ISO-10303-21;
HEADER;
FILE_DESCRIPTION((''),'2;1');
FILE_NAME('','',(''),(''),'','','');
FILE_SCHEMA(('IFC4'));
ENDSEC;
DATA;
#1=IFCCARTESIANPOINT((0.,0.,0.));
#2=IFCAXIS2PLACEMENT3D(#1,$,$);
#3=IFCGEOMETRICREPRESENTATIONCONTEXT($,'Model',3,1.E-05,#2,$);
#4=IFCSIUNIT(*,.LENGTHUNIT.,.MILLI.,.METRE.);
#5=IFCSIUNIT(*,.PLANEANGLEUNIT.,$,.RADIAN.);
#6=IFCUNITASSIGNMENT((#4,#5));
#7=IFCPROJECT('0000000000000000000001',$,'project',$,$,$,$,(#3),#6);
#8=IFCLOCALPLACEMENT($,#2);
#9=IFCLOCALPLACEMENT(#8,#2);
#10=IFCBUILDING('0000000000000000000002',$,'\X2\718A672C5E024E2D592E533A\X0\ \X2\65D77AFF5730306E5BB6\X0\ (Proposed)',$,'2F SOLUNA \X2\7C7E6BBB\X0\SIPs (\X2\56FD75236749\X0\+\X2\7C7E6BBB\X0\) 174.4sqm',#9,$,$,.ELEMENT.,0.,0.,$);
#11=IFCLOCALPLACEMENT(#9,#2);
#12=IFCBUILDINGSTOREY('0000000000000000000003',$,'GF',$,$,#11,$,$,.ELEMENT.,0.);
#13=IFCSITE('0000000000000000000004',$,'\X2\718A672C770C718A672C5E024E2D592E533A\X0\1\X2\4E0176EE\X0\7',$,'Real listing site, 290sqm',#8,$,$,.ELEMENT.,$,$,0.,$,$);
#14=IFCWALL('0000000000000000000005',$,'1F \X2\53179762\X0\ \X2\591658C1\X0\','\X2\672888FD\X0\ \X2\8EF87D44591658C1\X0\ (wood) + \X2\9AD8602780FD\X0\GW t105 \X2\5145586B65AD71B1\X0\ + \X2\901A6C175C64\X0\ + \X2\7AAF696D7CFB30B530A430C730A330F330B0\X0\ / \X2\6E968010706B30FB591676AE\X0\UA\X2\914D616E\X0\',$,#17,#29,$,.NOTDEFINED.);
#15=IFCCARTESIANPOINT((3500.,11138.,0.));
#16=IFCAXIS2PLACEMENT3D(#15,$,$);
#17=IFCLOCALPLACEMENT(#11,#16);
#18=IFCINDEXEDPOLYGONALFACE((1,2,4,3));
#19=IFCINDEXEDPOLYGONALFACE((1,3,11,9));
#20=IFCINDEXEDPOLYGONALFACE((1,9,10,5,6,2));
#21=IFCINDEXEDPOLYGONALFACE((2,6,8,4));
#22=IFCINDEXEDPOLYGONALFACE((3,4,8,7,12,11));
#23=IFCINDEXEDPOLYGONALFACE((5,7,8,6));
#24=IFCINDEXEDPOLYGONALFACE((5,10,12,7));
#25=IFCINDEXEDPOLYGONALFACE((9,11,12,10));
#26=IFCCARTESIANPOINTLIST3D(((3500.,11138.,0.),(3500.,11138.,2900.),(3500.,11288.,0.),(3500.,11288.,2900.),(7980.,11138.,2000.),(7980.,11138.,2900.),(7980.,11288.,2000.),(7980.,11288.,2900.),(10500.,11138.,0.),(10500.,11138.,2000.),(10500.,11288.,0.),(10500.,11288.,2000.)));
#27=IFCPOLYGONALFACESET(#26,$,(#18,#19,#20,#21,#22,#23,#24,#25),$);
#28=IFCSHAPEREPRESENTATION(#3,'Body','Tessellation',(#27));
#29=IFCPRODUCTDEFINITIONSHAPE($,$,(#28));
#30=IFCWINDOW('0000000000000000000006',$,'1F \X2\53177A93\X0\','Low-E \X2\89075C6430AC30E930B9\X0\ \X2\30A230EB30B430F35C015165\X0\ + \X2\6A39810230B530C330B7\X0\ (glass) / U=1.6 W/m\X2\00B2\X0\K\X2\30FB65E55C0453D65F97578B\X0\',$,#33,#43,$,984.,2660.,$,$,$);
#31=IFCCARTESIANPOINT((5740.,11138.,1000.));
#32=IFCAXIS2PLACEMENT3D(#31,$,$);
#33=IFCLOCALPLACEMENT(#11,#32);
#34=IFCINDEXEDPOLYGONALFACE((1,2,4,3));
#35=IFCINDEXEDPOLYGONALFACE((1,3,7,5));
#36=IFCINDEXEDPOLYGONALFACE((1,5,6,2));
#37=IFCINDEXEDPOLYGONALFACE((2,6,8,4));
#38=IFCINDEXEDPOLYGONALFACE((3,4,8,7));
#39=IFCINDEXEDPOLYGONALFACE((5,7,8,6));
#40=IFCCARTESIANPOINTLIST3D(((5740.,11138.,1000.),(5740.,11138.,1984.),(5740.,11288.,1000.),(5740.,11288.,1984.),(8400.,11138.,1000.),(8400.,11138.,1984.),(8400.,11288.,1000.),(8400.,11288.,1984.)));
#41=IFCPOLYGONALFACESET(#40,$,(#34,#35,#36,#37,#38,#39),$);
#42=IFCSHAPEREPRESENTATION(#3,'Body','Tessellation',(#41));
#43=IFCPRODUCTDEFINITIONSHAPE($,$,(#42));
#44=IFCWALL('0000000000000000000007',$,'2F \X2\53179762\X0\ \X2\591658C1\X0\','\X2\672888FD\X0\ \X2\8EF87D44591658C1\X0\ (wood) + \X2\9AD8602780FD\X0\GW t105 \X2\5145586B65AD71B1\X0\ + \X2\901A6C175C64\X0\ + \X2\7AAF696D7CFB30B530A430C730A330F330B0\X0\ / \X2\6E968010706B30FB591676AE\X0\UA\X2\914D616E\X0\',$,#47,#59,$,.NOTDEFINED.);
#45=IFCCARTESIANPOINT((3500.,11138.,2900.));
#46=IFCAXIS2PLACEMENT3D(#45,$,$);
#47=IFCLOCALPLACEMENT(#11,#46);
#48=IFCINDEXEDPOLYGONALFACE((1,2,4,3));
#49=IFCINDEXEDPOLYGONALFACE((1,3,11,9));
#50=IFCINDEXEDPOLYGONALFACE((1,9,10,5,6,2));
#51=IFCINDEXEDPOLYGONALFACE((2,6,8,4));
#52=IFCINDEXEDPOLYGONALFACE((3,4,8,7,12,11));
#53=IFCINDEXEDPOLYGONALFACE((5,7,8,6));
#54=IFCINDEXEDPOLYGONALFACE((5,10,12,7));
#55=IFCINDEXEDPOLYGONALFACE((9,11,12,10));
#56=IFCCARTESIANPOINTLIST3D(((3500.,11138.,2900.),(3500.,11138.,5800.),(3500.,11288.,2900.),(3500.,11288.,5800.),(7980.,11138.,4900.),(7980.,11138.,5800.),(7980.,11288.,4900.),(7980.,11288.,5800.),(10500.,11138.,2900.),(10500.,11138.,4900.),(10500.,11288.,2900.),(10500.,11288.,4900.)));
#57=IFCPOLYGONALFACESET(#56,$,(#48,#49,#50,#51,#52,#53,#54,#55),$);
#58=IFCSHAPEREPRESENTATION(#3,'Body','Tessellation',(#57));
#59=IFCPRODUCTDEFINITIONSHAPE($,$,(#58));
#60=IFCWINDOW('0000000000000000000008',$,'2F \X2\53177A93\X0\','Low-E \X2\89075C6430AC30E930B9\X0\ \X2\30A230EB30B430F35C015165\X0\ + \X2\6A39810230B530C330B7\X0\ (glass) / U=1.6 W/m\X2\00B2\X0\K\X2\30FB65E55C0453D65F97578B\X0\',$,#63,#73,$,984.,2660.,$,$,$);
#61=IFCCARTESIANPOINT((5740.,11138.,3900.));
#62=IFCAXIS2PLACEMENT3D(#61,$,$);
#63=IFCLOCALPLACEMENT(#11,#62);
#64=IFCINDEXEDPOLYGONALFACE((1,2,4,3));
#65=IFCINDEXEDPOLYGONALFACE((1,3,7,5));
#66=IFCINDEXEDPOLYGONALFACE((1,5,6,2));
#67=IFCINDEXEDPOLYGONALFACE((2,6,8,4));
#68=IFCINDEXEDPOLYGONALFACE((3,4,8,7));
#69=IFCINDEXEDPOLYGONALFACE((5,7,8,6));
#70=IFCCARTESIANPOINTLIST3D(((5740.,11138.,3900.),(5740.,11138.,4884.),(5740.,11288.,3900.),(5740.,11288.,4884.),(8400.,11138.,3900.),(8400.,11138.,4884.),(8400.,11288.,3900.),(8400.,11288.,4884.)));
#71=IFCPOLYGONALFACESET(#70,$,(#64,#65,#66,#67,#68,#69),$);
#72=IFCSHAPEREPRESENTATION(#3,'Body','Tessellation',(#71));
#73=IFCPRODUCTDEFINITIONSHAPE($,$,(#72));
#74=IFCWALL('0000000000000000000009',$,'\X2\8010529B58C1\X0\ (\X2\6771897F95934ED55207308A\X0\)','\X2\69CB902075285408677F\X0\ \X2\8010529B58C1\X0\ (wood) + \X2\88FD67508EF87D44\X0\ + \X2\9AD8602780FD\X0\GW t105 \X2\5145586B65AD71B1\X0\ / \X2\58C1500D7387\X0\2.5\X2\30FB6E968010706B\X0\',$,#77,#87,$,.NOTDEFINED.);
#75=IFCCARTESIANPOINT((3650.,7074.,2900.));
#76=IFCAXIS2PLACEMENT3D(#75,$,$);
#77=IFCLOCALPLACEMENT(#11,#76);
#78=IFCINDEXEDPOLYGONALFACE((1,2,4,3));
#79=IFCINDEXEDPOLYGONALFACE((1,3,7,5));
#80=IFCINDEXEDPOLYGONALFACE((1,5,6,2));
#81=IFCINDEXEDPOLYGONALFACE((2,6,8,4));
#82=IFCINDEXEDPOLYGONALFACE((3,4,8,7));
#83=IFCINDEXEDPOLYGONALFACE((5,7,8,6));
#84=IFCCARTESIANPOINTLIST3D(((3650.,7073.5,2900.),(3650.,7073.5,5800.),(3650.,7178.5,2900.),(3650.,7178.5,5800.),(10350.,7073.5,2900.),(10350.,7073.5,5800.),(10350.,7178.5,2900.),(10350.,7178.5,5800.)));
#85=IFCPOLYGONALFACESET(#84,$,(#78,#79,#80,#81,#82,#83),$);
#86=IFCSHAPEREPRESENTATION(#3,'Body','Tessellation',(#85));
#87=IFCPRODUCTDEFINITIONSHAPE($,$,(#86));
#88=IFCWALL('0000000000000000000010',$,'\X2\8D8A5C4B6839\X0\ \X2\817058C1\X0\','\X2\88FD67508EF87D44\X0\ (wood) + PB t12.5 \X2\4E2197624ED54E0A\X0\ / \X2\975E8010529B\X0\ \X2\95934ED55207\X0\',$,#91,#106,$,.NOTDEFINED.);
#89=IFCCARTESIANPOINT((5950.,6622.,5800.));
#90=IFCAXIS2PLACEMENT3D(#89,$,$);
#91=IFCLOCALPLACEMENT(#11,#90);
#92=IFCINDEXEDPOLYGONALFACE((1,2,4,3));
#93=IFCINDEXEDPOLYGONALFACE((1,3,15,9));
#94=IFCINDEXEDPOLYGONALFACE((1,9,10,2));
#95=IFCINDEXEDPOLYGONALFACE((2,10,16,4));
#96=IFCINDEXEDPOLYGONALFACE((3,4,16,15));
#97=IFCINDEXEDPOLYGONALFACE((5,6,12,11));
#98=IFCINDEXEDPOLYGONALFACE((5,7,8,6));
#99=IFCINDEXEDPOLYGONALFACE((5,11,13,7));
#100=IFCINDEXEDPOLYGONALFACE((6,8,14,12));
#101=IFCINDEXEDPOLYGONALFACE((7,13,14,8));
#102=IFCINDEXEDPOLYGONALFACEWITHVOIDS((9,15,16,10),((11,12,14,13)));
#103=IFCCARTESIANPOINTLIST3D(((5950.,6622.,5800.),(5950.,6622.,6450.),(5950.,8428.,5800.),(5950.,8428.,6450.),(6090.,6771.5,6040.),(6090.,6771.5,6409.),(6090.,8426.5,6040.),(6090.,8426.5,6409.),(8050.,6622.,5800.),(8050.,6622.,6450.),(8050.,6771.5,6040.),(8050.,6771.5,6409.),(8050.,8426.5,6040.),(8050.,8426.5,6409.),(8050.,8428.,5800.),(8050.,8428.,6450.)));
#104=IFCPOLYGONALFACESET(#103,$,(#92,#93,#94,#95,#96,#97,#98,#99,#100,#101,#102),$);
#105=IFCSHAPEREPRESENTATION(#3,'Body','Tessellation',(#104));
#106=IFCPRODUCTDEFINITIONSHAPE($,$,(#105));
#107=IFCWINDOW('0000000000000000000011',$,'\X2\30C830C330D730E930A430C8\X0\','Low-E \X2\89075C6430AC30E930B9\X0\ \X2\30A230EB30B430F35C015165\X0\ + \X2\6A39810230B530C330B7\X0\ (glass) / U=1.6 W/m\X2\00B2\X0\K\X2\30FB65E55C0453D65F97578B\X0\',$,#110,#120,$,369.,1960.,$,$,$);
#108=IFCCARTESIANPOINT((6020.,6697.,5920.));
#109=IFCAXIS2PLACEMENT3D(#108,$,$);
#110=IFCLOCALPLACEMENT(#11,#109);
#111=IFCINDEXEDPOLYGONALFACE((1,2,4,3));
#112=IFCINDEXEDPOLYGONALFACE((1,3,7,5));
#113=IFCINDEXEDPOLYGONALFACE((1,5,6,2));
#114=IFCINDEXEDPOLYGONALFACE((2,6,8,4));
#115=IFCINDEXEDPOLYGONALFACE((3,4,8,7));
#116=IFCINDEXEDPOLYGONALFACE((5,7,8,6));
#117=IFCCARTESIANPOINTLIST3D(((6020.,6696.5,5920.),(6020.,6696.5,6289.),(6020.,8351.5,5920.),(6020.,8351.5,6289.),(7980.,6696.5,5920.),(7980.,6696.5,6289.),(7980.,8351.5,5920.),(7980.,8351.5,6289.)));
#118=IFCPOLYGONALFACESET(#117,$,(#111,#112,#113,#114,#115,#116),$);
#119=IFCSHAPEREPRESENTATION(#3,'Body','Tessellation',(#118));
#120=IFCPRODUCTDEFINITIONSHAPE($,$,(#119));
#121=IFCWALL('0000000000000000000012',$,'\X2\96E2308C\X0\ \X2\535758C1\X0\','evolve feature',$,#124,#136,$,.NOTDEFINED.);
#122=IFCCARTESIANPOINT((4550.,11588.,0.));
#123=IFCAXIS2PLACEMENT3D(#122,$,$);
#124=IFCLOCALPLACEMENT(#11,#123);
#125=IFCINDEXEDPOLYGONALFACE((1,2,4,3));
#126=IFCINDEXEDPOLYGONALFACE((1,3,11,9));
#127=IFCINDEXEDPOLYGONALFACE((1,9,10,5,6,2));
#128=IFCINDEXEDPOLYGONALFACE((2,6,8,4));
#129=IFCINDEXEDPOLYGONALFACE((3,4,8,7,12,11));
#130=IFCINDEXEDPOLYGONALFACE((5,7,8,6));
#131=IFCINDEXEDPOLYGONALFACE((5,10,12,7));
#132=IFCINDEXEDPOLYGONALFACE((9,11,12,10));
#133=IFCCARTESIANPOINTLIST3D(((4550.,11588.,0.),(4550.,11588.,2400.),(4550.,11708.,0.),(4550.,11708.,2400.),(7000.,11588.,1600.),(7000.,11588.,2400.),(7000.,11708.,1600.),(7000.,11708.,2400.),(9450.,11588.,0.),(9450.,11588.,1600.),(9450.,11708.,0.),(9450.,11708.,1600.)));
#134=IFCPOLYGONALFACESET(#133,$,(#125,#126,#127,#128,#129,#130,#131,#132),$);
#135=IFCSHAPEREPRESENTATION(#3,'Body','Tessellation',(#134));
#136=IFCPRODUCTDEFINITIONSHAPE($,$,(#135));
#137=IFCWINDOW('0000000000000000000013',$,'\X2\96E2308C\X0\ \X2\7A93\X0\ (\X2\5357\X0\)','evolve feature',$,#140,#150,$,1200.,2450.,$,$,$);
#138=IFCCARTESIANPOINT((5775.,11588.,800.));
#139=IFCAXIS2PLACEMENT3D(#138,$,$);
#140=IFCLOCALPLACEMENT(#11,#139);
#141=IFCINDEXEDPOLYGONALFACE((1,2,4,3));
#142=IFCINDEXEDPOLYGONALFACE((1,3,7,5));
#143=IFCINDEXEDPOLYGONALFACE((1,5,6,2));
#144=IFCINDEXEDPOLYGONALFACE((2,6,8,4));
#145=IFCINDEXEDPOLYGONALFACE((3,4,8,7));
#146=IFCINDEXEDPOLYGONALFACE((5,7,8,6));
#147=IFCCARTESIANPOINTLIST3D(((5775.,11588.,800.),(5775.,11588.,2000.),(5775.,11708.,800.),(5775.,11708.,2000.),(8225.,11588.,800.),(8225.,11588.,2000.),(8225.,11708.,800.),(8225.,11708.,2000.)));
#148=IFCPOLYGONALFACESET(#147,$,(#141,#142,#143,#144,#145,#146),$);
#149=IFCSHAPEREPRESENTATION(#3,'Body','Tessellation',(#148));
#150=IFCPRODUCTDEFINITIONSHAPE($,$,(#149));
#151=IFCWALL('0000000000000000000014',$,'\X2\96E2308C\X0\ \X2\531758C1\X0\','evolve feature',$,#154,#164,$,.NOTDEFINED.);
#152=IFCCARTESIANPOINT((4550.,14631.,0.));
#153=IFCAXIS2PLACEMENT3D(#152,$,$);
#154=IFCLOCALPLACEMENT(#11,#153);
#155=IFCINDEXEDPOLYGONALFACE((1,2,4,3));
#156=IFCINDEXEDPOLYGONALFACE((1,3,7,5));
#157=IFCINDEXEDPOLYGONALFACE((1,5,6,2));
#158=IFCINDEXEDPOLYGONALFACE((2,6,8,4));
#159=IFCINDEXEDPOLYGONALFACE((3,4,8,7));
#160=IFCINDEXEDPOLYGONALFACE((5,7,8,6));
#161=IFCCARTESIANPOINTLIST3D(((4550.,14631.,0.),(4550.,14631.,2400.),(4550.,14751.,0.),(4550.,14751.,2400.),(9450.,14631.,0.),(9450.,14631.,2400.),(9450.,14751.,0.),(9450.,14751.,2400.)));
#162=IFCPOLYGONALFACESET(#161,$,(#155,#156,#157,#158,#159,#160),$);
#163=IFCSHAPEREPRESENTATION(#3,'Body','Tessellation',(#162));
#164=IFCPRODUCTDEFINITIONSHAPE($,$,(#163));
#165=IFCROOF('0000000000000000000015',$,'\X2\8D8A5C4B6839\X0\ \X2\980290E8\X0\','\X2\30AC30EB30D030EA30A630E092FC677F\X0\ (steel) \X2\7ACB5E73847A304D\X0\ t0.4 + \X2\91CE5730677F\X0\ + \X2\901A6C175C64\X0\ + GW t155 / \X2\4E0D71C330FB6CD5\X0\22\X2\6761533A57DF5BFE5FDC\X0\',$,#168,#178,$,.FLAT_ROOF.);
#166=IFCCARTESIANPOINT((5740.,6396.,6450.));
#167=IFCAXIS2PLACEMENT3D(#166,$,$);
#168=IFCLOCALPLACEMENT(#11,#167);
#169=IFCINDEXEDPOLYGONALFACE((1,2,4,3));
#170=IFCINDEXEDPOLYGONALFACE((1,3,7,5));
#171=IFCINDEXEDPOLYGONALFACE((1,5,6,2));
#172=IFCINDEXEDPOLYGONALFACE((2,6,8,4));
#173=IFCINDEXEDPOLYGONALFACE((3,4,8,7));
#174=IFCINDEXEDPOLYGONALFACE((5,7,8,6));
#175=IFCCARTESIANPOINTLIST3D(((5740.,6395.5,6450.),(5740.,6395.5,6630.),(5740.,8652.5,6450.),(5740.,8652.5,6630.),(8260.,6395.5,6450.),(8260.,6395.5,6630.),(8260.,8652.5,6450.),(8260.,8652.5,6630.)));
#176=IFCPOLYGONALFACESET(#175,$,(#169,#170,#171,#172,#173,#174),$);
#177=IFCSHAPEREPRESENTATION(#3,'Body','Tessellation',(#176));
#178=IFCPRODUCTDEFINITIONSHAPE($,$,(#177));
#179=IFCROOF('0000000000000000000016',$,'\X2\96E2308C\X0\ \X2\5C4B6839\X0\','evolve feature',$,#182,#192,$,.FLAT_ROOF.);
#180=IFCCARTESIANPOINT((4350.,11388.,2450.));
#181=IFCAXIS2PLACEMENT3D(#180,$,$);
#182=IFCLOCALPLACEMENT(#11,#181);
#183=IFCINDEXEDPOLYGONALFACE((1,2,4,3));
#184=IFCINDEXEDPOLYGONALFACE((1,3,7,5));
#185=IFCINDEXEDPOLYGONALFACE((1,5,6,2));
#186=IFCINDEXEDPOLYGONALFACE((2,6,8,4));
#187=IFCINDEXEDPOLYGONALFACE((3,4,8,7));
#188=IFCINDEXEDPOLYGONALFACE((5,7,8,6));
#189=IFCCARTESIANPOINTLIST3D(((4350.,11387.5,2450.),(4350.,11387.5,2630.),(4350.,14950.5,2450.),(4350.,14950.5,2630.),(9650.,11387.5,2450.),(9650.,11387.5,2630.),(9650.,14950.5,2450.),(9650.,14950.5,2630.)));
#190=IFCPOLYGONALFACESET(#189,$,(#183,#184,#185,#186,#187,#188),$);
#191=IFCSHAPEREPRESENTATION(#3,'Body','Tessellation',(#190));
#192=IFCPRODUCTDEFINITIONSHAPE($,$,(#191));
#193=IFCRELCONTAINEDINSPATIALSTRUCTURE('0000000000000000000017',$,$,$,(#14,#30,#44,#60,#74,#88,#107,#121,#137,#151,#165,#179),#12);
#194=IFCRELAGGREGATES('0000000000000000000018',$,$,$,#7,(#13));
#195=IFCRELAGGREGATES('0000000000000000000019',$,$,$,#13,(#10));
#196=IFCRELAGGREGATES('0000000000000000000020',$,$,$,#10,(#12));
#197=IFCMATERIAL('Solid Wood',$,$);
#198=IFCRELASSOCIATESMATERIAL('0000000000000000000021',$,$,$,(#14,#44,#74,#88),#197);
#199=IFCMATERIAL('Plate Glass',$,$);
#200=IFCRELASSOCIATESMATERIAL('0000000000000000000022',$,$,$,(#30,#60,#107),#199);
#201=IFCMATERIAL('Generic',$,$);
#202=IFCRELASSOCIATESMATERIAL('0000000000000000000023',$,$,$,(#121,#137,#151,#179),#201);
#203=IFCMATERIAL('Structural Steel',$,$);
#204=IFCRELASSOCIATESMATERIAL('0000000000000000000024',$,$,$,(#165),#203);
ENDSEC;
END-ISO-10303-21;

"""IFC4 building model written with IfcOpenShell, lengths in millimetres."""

from ifc_helpers import new_model, si_unit, frame, frame_2d, origin, place, context, project, spatial, rectangle, extrude, material, element, fill, save


model = new_model("IFC4")

# Units and contexts
model_context = context("Model", 3, precision=1e-05, world=origin())
ifc_project = project(units=[si_unit("LENGTHUNIT", "METRE", prefix="MILLI"), si_unit("PLANEANGLEUNIT", "RADIAN")], contexts=[model_context])

# Site, building, storey
site_placement = place(None, origin())
site = spatial("IfcSite", under=ifc_project, at=site_placement, Name="熊本県熊本市中央区1丁目7", ObjectType="Real listing site, 290sqm", CompositionType="ELEMENT", RefElevation=0.0)
building_placement = place(site_placement, origin())
building = spatial("IfcBuilding", under=site, at=building_placement, Name="熊本市中央区 旗竿地の家 (Proposed)", ObjectType="2F SOLUNA 籾殻SIPs (国産杉+籾殻) 174.4sqm", CompositionType="ELEMENT", ElevationOfRefHeight=0.0, ElevationOfTerrain=0.0)
storey_placement = place(building_placement, origin())
storey = spatial("IfcBuildingStorey", under=building, at=storey_placement, Name="GF", CompositionType="ELEMENT", Elevation=0.0)

# Shared definitions
ifc_material_1 = material(Name="Generic")

# Wall, opening, window
ifc_material_2 = material(Name="Solid Wood")
wall_1_placement = place(storey_placement, frame((3500.0, 11138.0, 0.0)))
wall_1 = element("IfcWall", 1, at=wall_1_placement, inside=storey, material=ifc_material_2, Name="1F 北面 外壁", Description="木製 軸組外壁 (wood) + 高性能GW t105 充填断熱 + 通気層 + 窯業系サイディング / 準耐火・外皮UA配慮", PredefinedType="NOTDEFINED", context=model_context, shape_type="SweptSolid", body=[
    extrude(rectangle(XDim=7000.0, YDim=150.0, at=frame_2d((3500.0, 75.0))), frame((3500.0, 11138.0, 0.0)), (0.0, 0.0, 1.0), 2900.0),
])
opening_1_placement = place(storey_placement, frame((5740.0, 11138.0, 1000.0)))
opening_1 = element("IfcOpeningElement", 2, at=opening_1_placement, cuts=wall_1, PredefinedType="NOTDEFINED", context=model_context, shape_type="SweptSolid", body=[
    extrude(rectangle(XDim=2660.0, YDim=150.0, at=frame_2d((1330.0, 75.0))), frame((5740.0, 11138.0, 1000.0)), (0.0, 0.0, 1.0), 984.0),
])
ifc_material_3 = material(Name="Plate Glass")
window_1_placement = place(storey_placement, frame((5740.0, 11138.0, 1000.0)))
window_1 = element("IfcWindow", 3, at=window_1_placement, inside=storey, material=ifc_material_3, Name="1F 北窓", Description="Low-E 複層ガラス アルゴン封入 + 樹脂サッシ (glass) / U=1.6 W/m²K・日射取得型", OverallHeight=984.0, OverallWidth=2660.0, context=model_context, shape_type="SweptSolid", body=[
    extrude(rectangle(XDim=2660.0, YDim=150.0, at=frame_2d((1330.0, 75.0))), frame((5740.0, 11138.0, 1000.0)), (0.0, 0.0, 1.0), 984.0),
])
fill(opening_1, window_1)

# Wall, opening, window
wall_2_placement = place(storey_placement, frame((3500.0, 11138.0, 2900.0)))
wall_2 = element("IfcWall", 4, at=wall_2_placement, inside=storey, material=ifc_material_2, Name="2F 北面 外壁", Description="木製 軸組外壁 (wood) + 高性能GW t105 充填断熱 + 通気層 + 窯業系サイディング / 準耐火・外皮UA配慮", PredefinedType="NOTDEFINED", context=model_context, shape_type="SweptSolid", body=[
    extrude(rectangle(XDim=7000.0, YDim=150.0, at=frame_2d((3500.0, 75.0))), frame((3500.0, 11138.0, 2900.0)), (0.0, 0.0, 1.0), 2900.0),
])
opening_2_placement = place(storey_placement, frame((5740.0, 11138.0, 3900.0)))
opening_2 = element("IfcOpeningElement", 5, at=opening_2_placement, cuts=wall_2, PredefinedType="NOTDEFINED", context=model_context, shape_type="SweptSolid", body=[
    extrude(rectangle(XDim=2660.0, YDim=150.0, at=frame_2d((1330.0, 75.0))), frame((5740.0, 11138.0, 3900.0)), (0.0, 0.0, 1.0), 984.0),
])
window_2_placement = place(storey_placement, frame((5740.0, 11138.0, 3900.0)))
window_2 = element("IfcWindow", 6, at=window_2_placement, inside=storey, material=ifc_material_3, Name="2F 北窓", Description="Low-E 複層ガラス アルゴン封入 + 樹脂サッシ (glass) / U=1.6 W/m²K・日射取得型", OverallHeight=984.0, OverallWidth=2660.0, context=model_context, shape_type="SweptSolid", body=[
    extrude(rectangle(XDim=2660.0, YDim=150.0, at=frame_2d((1330.0, 75.0))), frame((5740.0, 11138.0, 3900.0)), (0.0, 0.0, 1.0), 984.0),
])
fill(opening_2, window_2)

# Wall
wall_3_placement = place(storey_placement, frame((3650.0, 7074.0, 2900.0)))
element("IfcWall", 7, at=wall_3_placement, inside=storey, material=ifc_material_2, Name="耐力壁 (東西間仕切り)", Description="構造用合板 耐力壁 (wood) + 製材軸組 + 高性能GW t105 充填断熱 / 壁倍率2.5・準耐火", PredefinedType="NOTDEFINED", context=model_context, shape_type="SweptSolid", body=[
    extrude(rectangle(XDim=6700.0, YDim=105.0, at=frame_2d((3350.0, 52.0))), frame((3650.0, 7074.0, 2900.0)), (0.0, 0.0, 1.0), 2900.0),
])

# Walls, openings, windows
wall_4_placement = place(storey_placement, frame((5950.0, 6622.0, 5800.0)))
wall_4 = element("IfcWall", 8, at=wall_4_placement, inside=storey, material=ifc_material_2, Name="越屋根 腰壁", Description="製材軸組 (wood) + PB t12.5 両面仕上 / 非耐力 間仕切", PredefinedType="NOTDEFINED", context=model_context, shape_type="SweptSolid", body=[
    extrude(rectangle(XDim=2100.0, YDim=1806.0, at=frame_2d((1050.0, 903.0))), frame((5950.0, 6622.0, 5800.0)), (0.0, 0.0, 1.0), 650.0),
])
opening_3_placement = place(storey_placement, frame((6020.0, 6697.0, 5920.0)))
opening_3 = element("IfcOpeningElement", 9, at=opening_3_placement, cuts=wall_4, PredefinedType="NOTDEFINED", context=model_context, shape_type="SweptSolid", body=[
    extrude(rectangle(XDim=1960.0, YDim=1655.0, at=frame_2d((980.0, 827.0))), frame((6020.0, 6697.0, 5920.0)), (0.0, 0.0, 1.0), 369.0),
])
window_3_placement = place(storey_placement, frame((6020.0, 6697.0, 5920.0)))
window_3 = element("IfcWindow", 10, at=window_3_placement, inside=storey, material=ifc_material_3, Name="トップライト", Description="Low-E 複層ガラス アルゴン封入 + 樹脂サッシ (glass) / U=1.6 W/m²K・日射取得型", OverallHeight=369.0, OverallWidth=1960.0, context=model_context, shape_type="SweptSolid", body=[
    extrude(rectangle(XDim=1960.0, YDim=1655.0, at=frame_2d((980.0, 827.0))), frame((6020.0, 6697.0, 5920.0)), (0.0, 0.0, 1.0), 369.0),
])
fill(opening_3, window_3)
wall_5_placement = place(storey_placement, frame((4550.0, 11588.0, 0.0)))
wall_5 = element("IfcWall", 11, at=wall_5_placement, inside=storey, material=ifc_material_1, Name="離れ 南壁", Description="evolve feature", PredefinedType="NOTDEFINED", context=model_context, shape_type="SweptSolid", body=[
    extrude(rectangle(XDim=4900.0, YDim=120.0, at=frame_2d((2450.0, 60.0))), frame((4550.0, 11588.0, 0.0)), (0.0, 0.0, 1.0), 2400.0),
])
opening_4_placement = place(storey_placement, frame((5775.0, 11588.0, 800.0)))
opening_4 = element("IfcOpeningElement", 12, at=opening_4_placement, cuts=wall_5, PredefinedType="NOTDEFINED", context=model_context, shape_type="SweptSolid", body=[
    extrude(rectangle(XDim=2450.0, YDim=120.0, at=frame_2d((1225.0, 60.0))), frame((5775.0, 11588.0, 800.0)), (0.0, 0.0, 1.0), 1200.0),
])
window_4_placement = place(storey_placement, frame((5775.0, 11588.0, 800.0)))
window_4 = element("IfcWindow", 13, at=window_4_placement, inside=storey, material=ifc_material_1, Name="離れ 窓 (南)", Description="evolve feature", OverallHeight=1200.0, OverallWidth=2450.0, context=model_context, shape_type="SweptSolid", body=[
    extrude(rectangle(XDim=2450.0, YDim=120.0, at=frame_2d((1225.0, 60.0))), frame((5775.0, 11588.0, 800.0)), (0.0, 0.0, 1.0), 1200.0),
])
fill(opening_4, window_4)

# Wall
wall_6_placement = place(storey_placement, frame((4550.0, 14631.0, 0.0)))
element("IfcWall", 14, at=wall_6_placement, inside=storey, material=ifc_material_1, Name="離れ 北壁", Description="evolve feature", PredefinedType="NOTDEFINED", context=model_context, shape_type="SweptSolid", body=[
    extrude(rectangle(XDim=4900.0, YDim=120.0, at=frame_2d((2450.0, 60.0))), frame((4550.0, 14631.0, 0.0)), (0.0, 0.0, 1.0), 2400.0),
])

# Roofs
ifc_material_4 = material(Name="Structural Steel")
roof_1_placement = place(storey_placement, frame((5740.0, 6396.0, 6450.0)))
element("IfcRoof", 15, at=roof_1_placement, inside=storey, material=ifc_material_4, Name="越屋根 頂部", Description="ガルバリウム鋼板 (steel) 立平葺き t0.4 + 野地板 + 通気層 + GW t155 / 不燃・法22条区域対応", PredefinedType="FLAT_ROOF", context=model_context, shape_type="SweptSolid", body=[
    extrude(rectangle(XDim=2520.0, YDim=2257.0, at=frame_2d((1260.0, 1128.0))), frame((5740.0, 6396.0, 6450.0)), (0.0, 0.0, 1.0), 180.0),
])
roof_2_placement = place(storey_placement, frame((4350.0, 11388.0, 2450.0)))
element("IfcRoof", 16, at=roof_2_placement, inside=storey, material=ifc_material_1, Name="離れ 屋根", Description="evolve feature", PredefinedType="FLAT_ROOF", context=model_context, shape_type="SweptSolid", body=[
    extrude(rectangle(XDim=5300.0, YDim=3563.0, at=frame_2d((2650.0, 1781.0))), frame((4350.0, 11388.0, 2450.0)), (0.0, 0.0, 1.0), 180.0),
])

save(model, "model.ifc")
